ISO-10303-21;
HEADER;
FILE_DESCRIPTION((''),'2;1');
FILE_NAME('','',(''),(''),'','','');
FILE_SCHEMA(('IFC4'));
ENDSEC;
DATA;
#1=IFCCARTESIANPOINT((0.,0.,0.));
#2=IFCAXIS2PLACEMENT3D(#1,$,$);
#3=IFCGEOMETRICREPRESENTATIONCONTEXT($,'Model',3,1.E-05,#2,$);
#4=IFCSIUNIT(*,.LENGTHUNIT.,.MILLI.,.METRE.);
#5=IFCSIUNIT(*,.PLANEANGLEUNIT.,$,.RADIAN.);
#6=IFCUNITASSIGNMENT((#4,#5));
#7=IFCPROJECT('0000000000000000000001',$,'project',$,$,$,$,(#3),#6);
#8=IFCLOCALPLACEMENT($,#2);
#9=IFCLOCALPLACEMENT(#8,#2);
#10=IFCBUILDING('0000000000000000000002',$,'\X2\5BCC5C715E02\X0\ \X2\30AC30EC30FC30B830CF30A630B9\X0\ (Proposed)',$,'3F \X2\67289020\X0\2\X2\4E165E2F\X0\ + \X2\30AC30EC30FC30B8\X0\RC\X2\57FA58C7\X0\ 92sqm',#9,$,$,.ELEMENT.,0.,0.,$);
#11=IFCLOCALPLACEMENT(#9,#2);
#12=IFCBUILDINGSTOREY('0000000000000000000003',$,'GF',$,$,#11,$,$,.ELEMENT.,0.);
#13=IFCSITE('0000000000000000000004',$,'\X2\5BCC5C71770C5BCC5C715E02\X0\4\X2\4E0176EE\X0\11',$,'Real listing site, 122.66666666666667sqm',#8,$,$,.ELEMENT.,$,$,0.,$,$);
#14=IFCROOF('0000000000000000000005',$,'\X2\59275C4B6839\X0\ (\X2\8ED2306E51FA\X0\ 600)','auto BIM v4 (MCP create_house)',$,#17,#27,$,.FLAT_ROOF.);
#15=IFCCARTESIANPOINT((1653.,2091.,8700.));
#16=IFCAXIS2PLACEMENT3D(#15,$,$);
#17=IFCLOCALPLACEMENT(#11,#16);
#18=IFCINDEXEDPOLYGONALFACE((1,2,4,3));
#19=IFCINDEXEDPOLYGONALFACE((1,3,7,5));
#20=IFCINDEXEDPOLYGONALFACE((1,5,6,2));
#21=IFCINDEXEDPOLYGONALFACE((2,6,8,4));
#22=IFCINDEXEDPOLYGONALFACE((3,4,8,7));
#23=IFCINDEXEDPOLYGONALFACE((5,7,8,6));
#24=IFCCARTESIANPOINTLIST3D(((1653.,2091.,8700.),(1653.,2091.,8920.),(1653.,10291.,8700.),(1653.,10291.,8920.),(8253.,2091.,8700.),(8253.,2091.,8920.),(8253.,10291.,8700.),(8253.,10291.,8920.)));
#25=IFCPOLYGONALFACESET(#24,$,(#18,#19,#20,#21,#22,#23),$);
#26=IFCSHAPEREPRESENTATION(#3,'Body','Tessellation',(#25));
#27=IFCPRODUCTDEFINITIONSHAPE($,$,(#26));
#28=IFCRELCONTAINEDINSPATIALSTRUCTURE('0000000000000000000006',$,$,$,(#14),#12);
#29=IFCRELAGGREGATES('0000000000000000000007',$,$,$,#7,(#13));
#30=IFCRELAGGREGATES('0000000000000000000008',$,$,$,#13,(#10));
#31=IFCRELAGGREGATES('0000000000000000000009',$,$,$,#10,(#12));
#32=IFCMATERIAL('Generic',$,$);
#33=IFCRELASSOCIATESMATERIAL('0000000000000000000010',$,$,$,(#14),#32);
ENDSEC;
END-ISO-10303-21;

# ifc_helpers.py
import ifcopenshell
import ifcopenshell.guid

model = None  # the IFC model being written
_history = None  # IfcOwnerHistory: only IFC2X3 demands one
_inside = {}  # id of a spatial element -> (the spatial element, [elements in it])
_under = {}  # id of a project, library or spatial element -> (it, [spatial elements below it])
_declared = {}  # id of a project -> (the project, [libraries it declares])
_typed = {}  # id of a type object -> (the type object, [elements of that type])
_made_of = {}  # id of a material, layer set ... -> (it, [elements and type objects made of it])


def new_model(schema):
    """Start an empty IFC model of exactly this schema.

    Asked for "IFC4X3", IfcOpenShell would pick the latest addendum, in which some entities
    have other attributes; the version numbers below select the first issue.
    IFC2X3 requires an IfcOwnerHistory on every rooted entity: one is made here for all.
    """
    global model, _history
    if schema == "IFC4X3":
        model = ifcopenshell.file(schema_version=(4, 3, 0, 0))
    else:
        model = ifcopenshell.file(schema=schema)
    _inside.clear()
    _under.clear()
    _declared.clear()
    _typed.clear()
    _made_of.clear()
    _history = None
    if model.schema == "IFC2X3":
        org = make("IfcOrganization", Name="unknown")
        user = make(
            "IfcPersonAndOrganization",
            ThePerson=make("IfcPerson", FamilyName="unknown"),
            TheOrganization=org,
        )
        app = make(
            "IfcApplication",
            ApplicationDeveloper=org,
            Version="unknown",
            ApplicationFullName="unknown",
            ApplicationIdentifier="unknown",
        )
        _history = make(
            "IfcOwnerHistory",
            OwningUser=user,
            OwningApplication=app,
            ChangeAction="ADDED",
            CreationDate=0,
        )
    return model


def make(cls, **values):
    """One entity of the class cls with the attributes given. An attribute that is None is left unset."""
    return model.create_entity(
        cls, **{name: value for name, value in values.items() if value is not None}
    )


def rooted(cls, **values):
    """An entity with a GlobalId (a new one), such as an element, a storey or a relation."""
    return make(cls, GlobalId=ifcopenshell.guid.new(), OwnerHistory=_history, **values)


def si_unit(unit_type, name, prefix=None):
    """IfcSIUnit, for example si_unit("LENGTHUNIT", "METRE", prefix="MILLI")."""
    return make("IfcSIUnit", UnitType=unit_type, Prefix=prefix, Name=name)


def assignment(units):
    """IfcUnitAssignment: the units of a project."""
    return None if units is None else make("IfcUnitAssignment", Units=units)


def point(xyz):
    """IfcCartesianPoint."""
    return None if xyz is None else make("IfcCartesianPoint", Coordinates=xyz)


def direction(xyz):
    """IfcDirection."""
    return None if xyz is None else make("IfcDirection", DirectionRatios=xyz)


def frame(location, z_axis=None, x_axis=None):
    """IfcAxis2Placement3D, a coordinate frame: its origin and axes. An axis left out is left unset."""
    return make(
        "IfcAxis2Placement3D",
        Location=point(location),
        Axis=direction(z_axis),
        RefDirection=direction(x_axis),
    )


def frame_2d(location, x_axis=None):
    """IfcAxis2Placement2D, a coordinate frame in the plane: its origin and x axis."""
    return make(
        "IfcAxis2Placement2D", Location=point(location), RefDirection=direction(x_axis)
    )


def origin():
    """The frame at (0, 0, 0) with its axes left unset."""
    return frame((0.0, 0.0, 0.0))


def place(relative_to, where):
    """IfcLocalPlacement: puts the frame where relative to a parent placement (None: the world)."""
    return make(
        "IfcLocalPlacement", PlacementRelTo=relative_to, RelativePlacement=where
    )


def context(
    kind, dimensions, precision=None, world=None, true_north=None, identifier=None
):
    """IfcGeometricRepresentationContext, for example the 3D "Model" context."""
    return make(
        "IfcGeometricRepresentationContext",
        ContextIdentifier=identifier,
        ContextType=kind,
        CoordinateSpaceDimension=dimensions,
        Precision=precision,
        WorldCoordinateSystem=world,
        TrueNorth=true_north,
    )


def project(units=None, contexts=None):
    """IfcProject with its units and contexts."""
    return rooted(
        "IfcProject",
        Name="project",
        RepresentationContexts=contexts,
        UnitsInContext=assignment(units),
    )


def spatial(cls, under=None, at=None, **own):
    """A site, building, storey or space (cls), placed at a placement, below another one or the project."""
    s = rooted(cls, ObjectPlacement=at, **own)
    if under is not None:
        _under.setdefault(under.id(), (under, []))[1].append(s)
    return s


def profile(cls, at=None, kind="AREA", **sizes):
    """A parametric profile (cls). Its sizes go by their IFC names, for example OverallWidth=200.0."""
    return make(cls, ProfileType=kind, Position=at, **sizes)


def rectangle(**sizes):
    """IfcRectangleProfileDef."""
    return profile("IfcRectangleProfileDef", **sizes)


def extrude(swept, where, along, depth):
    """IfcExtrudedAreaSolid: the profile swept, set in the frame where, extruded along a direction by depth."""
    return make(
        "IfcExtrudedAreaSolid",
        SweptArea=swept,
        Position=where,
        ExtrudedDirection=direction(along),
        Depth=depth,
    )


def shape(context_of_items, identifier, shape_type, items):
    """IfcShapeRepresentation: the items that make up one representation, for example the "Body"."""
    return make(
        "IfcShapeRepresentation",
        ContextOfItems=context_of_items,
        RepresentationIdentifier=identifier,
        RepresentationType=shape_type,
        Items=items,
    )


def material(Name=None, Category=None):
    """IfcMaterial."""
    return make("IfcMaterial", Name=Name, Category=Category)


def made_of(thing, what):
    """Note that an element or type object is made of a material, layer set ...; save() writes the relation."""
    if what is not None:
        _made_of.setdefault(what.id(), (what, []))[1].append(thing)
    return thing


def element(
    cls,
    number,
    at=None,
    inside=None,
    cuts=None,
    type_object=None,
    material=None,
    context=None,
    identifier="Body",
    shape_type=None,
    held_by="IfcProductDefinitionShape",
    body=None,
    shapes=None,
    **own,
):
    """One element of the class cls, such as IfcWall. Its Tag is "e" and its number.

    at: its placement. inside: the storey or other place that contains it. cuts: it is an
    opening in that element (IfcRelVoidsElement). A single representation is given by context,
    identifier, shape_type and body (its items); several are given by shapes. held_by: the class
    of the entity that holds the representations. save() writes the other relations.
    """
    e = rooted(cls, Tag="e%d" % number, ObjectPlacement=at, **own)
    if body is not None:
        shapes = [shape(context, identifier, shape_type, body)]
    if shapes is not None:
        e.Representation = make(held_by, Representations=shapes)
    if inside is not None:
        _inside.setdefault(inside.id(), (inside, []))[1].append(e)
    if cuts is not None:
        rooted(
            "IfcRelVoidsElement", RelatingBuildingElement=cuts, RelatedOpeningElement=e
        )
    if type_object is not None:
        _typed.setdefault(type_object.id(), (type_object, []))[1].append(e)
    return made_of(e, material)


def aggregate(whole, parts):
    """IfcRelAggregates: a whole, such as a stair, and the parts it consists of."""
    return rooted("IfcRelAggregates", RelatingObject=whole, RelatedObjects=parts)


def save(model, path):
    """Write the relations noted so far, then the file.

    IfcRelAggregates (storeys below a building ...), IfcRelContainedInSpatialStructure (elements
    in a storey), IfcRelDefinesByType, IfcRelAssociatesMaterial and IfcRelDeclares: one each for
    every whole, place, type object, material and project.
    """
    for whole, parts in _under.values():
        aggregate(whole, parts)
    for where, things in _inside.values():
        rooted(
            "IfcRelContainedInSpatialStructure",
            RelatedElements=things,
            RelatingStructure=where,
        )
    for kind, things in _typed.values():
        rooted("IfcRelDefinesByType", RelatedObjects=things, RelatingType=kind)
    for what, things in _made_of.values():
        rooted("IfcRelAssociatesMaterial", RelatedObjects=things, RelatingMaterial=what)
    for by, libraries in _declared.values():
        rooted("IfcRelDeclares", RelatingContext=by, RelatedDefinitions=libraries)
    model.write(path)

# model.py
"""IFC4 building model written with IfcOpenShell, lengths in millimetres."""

from ifc_helpers import new_model, si_unit, frame, frame_2d, origin, place, context, project, spatial, rectangle, extrude, material, element, save


model = new_model("IFC4")

# Units and contexts
model_context = context("Model", 3, precision=1e-05, world=origin())
ifc_project = project(units=[si_unit("LENGTHUNIT", "METRE", prefix="MILLI"), si_unit("PLANEANGLEUNIT", "RADIAN")], contexts=[model_context])

# Site, building, storey
site_placement = place(None, origin())
site = spatial("IfcSite", under=ifc_project, at=site_placement, Name="富山県富山市4丁目11", ObjectType="Real listing site, 122.66666666666667sqm", CompositionType="ELEMENT", RefElevation=0.0)
building_placement = place(site_placement, origin())
building = spatial("IfcBuilding", under=site, at=building_placement, Name="富山市 ガレージハウス (Proposed)", ObjectType="3F 木造2世帯 + ガレージRC基壇 92sqm", CompositionType="ELEMENT", ElevationOfRefHeight=0.0, ElevationOfTerrain=0.0)
storey_placement = place(building_placement, origin())
storey = spatial("IfcBuildingStorey", under=building, at=storey_placement, Name="GF", CompositionType="ELEMENT", Elevation=0.0)

# Shared definitions
ifc_material = material(Name="Generic")

# Roof
roof_placement = place(storey_placement, frame((1653.0, 2091.0, 8700.0)))
element("IfcRoof", 1, at=roof_placement, inside=storey, material=ifc_material, Name="大屋根 (軒の出 600)", Description="auto BIM v4 (MCP create_house)", PredefinedType="FLAT_ROOF", context=model_context, shape_type="SweptSolid", body=[
    extrude(rectangle(XDim=6600.0, YDim=8200.0, at=frame_2d((3300.0, 4100.0))), frame((1653.0, 2091.0, 8700.0)), (0.0, 0.0, 1.0), 220.0),
])

save(model, "model.ifc")
